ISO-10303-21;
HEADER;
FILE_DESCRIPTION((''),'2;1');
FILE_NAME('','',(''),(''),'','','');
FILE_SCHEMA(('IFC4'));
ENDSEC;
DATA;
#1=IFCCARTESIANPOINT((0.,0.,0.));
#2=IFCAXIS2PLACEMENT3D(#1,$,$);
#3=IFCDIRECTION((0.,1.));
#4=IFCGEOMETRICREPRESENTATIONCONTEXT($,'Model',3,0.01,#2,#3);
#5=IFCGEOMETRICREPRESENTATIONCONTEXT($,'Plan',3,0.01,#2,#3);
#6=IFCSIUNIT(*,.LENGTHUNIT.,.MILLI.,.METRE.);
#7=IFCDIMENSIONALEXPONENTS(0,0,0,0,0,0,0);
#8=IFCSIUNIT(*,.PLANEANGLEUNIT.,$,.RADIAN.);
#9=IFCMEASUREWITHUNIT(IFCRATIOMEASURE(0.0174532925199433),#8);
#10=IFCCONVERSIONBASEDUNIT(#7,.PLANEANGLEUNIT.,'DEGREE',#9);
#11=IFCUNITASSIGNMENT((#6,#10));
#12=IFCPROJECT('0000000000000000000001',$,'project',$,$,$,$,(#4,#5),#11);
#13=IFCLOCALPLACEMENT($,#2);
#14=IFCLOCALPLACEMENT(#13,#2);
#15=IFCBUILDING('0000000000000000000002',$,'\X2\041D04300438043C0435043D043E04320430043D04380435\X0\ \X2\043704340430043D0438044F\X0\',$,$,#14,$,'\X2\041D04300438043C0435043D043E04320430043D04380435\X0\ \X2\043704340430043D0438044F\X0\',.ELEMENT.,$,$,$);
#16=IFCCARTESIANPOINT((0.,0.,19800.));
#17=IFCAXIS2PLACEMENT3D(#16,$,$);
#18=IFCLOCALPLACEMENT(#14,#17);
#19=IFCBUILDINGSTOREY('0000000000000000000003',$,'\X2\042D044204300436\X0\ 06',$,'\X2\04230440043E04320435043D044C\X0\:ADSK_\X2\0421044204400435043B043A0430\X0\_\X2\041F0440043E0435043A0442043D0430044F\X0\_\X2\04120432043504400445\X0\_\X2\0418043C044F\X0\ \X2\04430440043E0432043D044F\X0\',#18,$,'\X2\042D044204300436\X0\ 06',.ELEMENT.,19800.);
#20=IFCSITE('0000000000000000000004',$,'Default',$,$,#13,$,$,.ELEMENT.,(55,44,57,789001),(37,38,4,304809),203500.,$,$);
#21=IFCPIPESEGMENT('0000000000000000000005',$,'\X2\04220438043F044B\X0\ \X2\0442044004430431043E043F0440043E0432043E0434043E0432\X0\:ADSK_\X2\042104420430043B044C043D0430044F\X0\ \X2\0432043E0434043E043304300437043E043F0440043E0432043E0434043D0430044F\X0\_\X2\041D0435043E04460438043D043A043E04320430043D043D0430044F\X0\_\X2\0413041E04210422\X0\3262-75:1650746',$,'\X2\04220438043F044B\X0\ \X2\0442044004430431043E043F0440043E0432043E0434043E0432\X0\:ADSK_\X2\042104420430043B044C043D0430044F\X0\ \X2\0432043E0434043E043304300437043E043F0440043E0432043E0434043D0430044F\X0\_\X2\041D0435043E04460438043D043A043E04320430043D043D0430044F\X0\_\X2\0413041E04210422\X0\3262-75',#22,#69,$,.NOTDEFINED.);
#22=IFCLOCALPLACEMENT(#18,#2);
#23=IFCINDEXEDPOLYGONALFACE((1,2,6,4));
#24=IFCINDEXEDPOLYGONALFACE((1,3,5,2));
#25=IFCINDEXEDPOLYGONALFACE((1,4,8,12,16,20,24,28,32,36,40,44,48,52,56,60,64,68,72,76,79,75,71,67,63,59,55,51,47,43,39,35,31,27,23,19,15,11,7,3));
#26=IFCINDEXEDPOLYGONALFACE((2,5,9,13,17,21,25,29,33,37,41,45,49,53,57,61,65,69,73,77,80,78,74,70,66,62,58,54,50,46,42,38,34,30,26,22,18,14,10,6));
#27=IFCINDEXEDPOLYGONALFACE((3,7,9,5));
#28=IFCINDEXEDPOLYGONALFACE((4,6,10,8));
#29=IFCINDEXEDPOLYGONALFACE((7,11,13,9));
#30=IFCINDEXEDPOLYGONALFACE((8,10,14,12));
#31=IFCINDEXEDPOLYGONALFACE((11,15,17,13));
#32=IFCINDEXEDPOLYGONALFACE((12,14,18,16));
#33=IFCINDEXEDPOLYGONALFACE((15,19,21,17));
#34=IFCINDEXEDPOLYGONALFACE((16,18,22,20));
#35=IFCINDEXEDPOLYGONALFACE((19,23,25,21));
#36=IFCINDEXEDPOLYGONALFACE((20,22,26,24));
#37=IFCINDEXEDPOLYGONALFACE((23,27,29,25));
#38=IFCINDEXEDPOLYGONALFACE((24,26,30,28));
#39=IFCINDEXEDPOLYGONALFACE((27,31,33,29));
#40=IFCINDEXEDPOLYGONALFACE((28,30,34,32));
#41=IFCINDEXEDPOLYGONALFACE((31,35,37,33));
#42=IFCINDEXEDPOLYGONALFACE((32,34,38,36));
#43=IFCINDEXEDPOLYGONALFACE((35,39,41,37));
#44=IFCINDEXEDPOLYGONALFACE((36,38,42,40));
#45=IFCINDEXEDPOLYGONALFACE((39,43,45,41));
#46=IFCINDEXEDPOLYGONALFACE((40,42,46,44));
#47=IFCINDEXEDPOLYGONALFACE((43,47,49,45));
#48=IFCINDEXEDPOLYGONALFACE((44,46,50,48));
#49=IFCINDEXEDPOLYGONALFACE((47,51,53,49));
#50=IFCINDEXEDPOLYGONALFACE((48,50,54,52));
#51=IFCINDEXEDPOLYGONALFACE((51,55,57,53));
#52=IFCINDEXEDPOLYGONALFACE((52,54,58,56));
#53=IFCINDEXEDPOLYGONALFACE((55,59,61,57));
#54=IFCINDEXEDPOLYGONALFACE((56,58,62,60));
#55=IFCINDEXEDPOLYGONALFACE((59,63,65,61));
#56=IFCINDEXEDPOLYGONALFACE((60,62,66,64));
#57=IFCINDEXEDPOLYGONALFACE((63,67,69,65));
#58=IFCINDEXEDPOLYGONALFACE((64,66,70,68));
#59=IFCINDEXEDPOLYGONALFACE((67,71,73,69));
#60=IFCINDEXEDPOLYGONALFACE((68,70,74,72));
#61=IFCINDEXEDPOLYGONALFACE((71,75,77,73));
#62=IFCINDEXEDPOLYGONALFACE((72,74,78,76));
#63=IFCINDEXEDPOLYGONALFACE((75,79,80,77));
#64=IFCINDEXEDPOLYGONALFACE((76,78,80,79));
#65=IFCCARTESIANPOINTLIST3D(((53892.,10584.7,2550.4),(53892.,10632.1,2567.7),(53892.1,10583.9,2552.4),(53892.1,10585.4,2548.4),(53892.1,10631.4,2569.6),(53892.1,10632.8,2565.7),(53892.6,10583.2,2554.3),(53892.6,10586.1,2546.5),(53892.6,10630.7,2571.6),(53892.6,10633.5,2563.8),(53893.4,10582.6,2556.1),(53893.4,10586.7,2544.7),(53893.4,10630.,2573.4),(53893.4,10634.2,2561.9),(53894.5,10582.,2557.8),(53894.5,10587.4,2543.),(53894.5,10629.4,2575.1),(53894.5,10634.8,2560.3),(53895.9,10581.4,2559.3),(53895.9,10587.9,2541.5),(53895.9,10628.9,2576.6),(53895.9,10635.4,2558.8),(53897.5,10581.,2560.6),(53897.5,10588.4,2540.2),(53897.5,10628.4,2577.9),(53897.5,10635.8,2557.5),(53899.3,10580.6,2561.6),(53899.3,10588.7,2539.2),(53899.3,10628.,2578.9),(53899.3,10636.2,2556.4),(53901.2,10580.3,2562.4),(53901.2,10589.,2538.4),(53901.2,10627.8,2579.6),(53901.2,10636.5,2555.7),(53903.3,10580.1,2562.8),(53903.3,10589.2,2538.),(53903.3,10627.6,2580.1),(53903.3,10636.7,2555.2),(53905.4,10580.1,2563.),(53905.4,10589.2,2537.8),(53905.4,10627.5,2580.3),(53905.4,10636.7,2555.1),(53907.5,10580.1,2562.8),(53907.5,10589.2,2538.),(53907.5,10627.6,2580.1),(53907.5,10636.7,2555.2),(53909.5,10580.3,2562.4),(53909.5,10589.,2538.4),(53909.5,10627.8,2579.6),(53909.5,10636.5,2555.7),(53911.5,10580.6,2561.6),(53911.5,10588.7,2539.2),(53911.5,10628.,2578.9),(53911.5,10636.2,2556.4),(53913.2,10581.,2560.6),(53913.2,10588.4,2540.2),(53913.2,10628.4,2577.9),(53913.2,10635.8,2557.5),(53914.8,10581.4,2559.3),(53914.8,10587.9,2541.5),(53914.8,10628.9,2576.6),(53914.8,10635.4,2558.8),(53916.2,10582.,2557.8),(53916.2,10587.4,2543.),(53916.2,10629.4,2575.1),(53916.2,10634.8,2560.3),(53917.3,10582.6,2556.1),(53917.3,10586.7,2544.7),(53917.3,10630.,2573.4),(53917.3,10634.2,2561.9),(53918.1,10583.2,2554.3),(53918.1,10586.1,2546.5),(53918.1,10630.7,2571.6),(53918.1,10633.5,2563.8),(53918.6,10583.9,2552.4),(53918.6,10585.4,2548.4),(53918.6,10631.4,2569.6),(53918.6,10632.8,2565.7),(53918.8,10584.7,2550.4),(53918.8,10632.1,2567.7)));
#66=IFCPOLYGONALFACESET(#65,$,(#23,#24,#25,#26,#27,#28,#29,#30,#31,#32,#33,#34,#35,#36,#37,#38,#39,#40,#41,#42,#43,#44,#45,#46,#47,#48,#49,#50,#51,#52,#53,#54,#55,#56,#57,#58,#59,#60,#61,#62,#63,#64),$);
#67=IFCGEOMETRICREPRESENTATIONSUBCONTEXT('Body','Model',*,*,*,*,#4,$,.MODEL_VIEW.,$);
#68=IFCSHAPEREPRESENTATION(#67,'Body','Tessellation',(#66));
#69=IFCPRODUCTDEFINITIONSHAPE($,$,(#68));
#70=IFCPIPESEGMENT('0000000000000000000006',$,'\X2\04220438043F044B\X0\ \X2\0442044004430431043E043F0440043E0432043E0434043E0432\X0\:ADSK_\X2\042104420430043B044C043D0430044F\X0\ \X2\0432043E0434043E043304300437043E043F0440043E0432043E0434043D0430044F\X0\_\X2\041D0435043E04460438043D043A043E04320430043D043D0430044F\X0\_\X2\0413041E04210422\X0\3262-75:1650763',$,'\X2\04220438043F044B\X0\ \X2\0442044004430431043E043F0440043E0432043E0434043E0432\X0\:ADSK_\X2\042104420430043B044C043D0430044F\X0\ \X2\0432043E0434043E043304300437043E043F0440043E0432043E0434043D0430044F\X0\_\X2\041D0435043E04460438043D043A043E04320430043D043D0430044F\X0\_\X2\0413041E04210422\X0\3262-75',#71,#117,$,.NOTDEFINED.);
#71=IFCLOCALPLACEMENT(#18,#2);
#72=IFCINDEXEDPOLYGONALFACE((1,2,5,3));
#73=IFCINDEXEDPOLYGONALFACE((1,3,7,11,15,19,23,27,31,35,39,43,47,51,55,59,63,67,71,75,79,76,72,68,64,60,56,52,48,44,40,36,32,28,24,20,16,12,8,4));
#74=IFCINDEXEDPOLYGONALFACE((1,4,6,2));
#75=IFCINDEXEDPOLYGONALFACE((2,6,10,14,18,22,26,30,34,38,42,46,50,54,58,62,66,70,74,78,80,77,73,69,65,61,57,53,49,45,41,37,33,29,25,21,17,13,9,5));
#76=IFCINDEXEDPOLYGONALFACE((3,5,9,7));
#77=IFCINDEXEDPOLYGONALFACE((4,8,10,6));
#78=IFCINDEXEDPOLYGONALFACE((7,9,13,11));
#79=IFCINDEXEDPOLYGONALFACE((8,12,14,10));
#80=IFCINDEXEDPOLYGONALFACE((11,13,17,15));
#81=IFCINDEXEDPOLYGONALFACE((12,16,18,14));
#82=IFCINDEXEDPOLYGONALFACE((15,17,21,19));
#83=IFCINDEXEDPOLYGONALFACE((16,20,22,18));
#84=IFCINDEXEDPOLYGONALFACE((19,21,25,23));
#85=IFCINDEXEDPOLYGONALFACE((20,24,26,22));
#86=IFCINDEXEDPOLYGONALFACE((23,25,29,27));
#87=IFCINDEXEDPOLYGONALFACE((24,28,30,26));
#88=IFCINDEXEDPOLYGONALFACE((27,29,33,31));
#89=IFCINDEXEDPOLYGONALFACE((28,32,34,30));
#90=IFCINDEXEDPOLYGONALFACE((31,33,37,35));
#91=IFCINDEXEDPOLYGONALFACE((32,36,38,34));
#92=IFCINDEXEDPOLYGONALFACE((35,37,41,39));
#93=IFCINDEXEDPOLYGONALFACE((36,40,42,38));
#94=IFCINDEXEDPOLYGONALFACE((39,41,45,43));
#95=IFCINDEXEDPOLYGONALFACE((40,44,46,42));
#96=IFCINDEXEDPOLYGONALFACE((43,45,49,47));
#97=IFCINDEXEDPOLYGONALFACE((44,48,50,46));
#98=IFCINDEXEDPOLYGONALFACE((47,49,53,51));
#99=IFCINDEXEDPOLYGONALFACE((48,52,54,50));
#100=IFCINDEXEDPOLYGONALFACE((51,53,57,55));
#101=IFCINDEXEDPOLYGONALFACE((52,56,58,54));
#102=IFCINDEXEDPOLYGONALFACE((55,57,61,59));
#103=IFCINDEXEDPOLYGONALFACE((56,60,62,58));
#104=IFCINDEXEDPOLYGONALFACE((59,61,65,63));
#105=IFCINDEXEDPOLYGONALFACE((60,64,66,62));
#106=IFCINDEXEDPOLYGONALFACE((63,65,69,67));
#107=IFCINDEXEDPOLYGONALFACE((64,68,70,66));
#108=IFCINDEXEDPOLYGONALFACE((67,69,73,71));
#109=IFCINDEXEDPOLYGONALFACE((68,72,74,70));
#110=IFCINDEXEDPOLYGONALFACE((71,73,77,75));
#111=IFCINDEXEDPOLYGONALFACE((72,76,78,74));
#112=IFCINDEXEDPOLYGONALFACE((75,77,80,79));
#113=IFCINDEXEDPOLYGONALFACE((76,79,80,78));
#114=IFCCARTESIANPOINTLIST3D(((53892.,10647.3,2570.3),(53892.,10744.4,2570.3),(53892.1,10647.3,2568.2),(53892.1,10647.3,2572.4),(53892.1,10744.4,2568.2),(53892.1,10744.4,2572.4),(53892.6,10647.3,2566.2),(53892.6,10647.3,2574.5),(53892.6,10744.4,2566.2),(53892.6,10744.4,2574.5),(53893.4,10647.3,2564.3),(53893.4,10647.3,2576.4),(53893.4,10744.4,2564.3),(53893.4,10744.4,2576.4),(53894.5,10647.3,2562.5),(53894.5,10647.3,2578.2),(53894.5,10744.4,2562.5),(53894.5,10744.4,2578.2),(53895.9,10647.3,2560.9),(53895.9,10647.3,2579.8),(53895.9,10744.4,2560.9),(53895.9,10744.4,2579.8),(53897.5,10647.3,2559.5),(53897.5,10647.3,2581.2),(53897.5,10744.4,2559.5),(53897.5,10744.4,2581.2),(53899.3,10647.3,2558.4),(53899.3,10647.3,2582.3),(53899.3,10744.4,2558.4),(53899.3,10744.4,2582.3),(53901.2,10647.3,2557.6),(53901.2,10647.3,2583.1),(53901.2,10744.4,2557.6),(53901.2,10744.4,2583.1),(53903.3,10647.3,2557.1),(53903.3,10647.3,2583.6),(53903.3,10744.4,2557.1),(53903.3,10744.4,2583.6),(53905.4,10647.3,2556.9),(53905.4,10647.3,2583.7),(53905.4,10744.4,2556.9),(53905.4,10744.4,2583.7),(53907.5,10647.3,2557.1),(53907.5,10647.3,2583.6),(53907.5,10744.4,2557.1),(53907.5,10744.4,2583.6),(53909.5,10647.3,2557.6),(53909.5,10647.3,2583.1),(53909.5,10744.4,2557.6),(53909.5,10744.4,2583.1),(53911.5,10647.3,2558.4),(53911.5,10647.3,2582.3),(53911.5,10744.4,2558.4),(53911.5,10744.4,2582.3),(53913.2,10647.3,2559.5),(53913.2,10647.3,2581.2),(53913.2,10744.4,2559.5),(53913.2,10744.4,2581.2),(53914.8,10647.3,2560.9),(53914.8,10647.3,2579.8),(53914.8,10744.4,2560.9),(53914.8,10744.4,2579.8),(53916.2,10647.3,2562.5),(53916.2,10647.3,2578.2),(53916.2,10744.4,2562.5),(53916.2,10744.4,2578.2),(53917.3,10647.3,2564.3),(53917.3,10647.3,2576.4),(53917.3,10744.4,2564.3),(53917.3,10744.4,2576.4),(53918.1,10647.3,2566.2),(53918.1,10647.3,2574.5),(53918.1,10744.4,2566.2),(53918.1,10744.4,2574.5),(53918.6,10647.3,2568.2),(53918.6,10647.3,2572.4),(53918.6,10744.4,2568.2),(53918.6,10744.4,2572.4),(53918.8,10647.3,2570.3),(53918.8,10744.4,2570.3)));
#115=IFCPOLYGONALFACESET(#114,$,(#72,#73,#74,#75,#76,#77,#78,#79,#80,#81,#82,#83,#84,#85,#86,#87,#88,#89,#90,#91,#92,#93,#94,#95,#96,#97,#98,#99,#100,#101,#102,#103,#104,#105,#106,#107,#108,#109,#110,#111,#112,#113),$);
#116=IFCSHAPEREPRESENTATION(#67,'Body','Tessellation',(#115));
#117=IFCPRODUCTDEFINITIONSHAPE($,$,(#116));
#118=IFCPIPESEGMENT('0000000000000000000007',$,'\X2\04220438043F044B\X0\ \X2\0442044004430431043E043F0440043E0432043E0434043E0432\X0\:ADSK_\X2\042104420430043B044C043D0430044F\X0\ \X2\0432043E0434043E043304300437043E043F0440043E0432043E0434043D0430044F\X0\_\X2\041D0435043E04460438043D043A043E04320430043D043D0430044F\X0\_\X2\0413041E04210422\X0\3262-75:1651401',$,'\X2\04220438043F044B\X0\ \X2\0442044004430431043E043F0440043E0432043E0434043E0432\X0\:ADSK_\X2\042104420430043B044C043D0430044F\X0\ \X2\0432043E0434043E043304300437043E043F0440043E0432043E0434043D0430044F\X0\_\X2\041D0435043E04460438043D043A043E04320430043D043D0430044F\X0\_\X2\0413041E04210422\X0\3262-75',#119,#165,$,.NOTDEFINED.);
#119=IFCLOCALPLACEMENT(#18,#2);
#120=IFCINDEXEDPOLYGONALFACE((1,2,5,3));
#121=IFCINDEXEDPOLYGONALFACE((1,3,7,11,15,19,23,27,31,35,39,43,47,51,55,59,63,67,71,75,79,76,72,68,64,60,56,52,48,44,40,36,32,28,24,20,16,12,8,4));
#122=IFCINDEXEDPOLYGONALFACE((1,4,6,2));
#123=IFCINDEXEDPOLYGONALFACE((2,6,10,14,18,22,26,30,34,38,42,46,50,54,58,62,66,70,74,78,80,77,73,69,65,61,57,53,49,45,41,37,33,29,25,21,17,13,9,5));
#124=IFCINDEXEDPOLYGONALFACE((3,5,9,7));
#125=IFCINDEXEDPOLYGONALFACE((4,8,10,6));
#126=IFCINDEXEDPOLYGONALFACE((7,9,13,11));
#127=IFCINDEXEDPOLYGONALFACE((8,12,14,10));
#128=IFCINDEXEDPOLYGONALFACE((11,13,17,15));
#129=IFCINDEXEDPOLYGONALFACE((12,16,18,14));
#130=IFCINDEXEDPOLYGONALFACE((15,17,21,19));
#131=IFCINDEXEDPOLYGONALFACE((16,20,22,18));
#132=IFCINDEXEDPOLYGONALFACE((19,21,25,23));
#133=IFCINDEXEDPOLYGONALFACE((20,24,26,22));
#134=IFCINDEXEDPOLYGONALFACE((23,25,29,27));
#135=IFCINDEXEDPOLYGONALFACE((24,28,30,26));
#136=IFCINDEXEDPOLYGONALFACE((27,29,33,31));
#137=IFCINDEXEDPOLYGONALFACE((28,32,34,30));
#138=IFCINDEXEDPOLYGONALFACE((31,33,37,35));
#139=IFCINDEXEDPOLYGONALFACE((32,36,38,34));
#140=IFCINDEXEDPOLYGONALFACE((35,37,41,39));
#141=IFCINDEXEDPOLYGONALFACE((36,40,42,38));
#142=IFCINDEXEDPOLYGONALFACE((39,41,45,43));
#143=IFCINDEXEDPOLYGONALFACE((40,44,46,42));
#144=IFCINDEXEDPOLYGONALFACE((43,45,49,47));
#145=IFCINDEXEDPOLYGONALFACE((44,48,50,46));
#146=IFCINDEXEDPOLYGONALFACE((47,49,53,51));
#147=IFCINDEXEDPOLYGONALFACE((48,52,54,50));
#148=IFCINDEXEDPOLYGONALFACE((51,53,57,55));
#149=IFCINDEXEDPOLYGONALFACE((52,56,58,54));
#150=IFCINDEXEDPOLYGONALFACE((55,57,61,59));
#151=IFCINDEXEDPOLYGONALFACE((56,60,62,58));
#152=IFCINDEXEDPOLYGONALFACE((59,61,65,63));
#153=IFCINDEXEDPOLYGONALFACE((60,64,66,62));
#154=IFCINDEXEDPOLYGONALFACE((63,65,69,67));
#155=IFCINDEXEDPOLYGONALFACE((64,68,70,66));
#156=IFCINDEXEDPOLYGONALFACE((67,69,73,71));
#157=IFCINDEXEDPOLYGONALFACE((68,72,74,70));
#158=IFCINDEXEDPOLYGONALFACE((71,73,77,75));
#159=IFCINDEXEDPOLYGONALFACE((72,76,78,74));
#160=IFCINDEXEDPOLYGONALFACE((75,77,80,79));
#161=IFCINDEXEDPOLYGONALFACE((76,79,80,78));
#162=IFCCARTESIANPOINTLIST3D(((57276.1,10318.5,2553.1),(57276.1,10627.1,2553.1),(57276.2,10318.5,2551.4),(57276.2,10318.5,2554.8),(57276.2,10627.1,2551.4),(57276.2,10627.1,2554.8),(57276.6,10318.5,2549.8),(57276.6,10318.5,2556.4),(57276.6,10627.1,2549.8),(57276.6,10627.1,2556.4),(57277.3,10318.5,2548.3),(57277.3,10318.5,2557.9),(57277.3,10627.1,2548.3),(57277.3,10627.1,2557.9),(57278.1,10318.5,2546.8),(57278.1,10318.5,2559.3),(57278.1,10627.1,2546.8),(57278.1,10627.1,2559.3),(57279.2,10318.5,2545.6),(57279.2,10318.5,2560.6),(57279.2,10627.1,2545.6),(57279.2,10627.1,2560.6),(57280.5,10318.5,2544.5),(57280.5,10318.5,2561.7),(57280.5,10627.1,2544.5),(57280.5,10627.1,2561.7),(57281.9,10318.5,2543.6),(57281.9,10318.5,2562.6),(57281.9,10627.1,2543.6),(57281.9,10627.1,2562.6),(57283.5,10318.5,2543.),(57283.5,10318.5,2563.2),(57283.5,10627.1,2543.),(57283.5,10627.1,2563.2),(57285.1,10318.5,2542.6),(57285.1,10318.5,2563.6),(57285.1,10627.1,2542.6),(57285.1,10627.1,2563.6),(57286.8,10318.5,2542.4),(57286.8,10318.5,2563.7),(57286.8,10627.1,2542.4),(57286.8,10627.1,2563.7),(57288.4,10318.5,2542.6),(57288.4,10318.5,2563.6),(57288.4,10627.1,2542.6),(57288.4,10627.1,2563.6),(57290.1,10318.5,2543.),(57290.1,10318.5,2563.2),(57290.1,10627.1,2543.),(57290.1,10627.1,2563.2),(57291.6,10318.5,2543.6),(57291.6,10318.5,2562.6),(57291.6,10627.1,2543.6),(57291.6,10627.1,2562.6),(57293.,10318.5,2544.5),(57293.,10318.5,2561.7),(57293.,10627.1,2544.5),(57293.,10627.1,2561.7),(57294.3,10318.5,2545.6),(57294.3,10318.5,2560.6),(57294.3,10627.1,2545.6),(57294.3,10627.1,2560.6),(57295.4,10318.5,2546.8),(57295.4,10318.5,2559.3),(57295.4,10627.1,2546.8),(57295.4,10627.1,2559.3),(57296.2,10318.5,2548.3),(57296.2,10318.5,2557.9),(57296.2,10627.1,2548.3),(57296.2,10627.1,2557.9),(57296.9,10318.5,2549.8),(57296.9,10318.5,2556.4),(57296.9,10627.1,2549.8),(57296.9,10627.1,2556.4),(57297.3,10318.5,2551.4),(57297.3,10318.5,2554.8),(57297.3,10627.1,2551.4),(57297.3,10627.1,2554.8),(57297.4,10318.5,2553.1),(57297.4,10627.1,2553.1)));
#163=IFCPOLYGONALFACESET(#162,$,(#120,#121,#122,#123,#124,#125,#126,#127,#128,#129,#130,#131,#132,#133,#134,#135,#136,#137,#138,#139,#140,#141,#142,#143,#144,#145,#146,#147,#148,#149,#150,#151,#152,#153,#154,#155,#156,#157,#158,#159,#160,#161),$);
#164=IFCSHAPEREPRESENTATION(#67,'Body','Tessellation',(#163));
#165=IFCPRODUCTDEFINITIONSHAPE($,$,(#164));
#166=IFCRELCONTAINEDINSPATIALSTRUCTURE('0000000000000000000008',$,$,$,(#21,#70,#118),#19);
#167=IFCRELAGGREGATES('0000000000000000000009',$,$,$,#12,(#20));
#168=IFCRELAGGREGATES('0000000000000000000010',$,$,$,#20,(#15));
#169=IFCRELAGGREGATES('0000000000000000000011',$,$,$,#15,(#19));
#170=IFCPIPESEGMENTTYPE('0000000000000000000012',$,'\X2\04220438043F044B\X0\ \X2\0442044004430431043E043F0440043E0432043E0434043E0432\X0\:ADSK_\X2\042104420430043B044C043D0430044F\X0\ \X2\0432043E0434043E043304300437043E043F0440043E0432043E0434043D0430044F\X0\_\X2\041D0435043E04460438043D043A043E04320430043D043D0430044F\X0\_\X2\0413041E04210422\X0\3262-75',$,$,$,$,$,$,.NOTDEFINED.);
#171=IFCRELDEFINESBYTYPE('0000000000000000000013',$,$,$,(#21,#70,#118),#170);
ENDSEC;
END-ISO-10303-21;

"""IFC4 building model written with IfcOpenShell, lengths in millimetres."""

from ifc_helpers import new_model, entity, si_unit, converted_unit, direction, frame, origin, place, context, subcontext, project, spatial, indexed_curve, outline, extrude, type_object, element, save


model = new_model("IFC4")

# Units and contexts
model_context = context("Model", 3, precision=0.01, world=origin(), true_north=direction((0.0, 1.0)))
plan_context = context("Plan", 3, precision=0.01, world=origin(), true_north=direction((0.0, 1.0)))
body_context = subcontext(model_context, "Body", "Model", "MODEL_VIEW")
ifc_project = project(units=[si_unit("LENGTHUNIT", "METRE", prefix="MILLI"), converted_unit("PLANEANGLEUNIT", "DEGREE", entity("IfcRatioMeasure", 0.0174532925199433), si_unit("PLANEANGLEUNIT", "RADIAN"), dimensions=[0, 0, 0, 0, 0, 0, 0])], contexts=[model_context, plan_context])

# Site, building, storey
site_placement = place(None, origin())
site = spatial("IfcSite", under=ifc_project, at=site_placement, Name="Default", CompositionType="ELEMENT", RefLatitude=(55, 44, 57, 789001), RefLongitude=(37, 38, 4, 304809), RefElevation=203500.0)
building_placement = place(site_placement, origin())
building = spatial("IfcBuilding", under=site, at=building_placement, Name="Наименование здания", LongName="Наименование здания", CompositionType="ELEMENT")
storey_placement = place(building_placement, frame((0.0, 0.0, 19800.0)))
storey = spatial("IfcBuildingStorey", under=building, at=storey_placement, Name="Этаж 06", ObjectType="Уровень:ADSK_Стрелка_Проектная_Вверх_Имя уровня", LongName="Этаж 06", CompositionType="ELEMENT", Elevation=19800.0)

# Pipe segments
pipe_segment_type = type_object("IfcPipeSegmentType", Name="Типы трубопроводов:ADSK_Стальная водогазопроводная_Неоцинкованная_ГОСТ3262-75", PredefinedType="NOTDEFINED")
placement = place(storey_placement, origin())
element("IfcPipeSegment", 1, at=placement, inside=storey, type_object=pipe_segment_type, Name="Типы трубопроводов:ADSK_Стальная водогазопроводная_Неоцинкованная_ГОСТ3262-75:1650746", ObjectType="Типы трубопроводов:ADSK_Стальная водогазопроводная_Неоцинкованная_ГОСТ3262-75", PredefinedType="NOTDEFINED", context=body_context, shape_type="SweptSolid", body=[
    extrude(outline(indexed_curve([(13.4, 0.0), (13.2, 2.1), (12.7, 4.1), (11.9, 6.1), (10.8, 7.9), (9.5, 9.5), (7.9, 10.8), (6.1, 11.9), (4.1, 12.7), (2.1, 13.2), (0.0, 13.4), (-2.1, 13.2), (-4.1, 12.7), (-6.1, 11.9), (-7.9, 10.8), (-9.5, 9.5), (-10.8, 7.9), (-11.9, 6.1), (-12.7, 4.1), (-13.2, 2.1), (-13.4, 0.0), (-13.2, -2.1), (-12.7, -4.1), (-11.9, -6.1), (-10.8, -7.9), (-9.5, -9.5), (-7.9, -10.8), (-6.1, -11.9), (-4.1, -12.7), (-2.1, -13.2), (0.0, -13.4), (2.1, -13.2), (4.1, -12.7), (6.1, -11.9), (7.9, -10.8), (9.5, -9.5), (10.8, -7.9), (11.9, -6.1), (12.7, -4.1), (13.2, -2.1), (13.4, 0.0)], self_intersect=False)), frame((53905.4, 10584.7, 2550.4), z_axis=(0.0, 0.939693, 0.34202), x_axis=(1.0, 0.0, 0.0)), (0.0, 0.0, 1.0), 50.5),
])
element("IfcPipeSegment", 2, at=placement, inside=storey, type_object=pipe_segment_type, Name="Типы трубопроводов:ADSK_Стальная водогазопроводная_Неоцинкованная_ГОСТ3262-75:1650763", ObjectType="Типы трубопроводов:ADSK_Стальная водогазопроводная_Неоцинкованная_ГОСТ3262-75", PredefinedType="NOTDEFINED", context=body_context, shape_type="SweptSolid", body=[
    extrude(outline(indexed_curve([(13.4, 0.0), (13.2, 2.1), (12.7, 4.1), (11.9, 6.1), (10.8, 7.9), (9.5, 9.5), (7.9, 10.8), (6.1, 11.9), (4.1, 12.7), (2.1, 13.2), (0.0, 13.4), (-2.1, 13.2), (-4.1, 12.7), (-6.1, 11.9), (-7.9, 10.8), (-9.5, 9.5), (-10.8, 7.9), (-11.9, 6.1), (-12.7, 4.1), (-13.2, 2.1), (-13.4, 0.0), (-13.2, -2.1), (-12.7, -4.1), (-11.9, -6.1), (-10.8, -7.9), (-9.5, -9.5), (-7.9, -10.8), (-6.1, -11.9), (-4.1, -12.7), (-2.1, -13.2), (0.0, -13.4), (2.1, -13.2), (4.1, -12.7), (6.1, -11.9), (7.9, -10.8), (9.5, -9.5), (10.8, -7.9), (11.9, -6.1), (12.7, -4.1), (13.2, -2.1), (13.4, 0.0)], self_intersect=False)), frame((53905.4, 10647.3, 2570.3), z_axis=(0.0, 1.0, 0.0), x_axis=(-1.0, 0.0, 0.0)), (0.0, 0.0, 1.0), 97.1),
])
element("IfcPipeSegment", 3, at=placement, inside=storey, type_object=pipe_segment_type, Name="Типы трубопроводов:ADSK_Стальная водогазопроводная_Неоцинкованная_ГОСТ3262-75:1651401", ObjectType="Типы трубопроводов:ADSK_Стальная водогазопроводная_Неоцинкованная_ГОСТ3262-75", PredefinedType="NOTDEFINED", context=body_context, shape_type="SweptSolid", body=[
    extrude(outline(indexed_curve([(10.7, 0.0), (10.5, 1.7), (10.1, 3.3), (9.5, 4.8), (8.6, 6.3), (7.5, 7.5), (6.3, 8.6), (4.8, 9.5), (3.3, 10.1), (1.7, 10.5), (0.0, 10.7), (-1.7, 10.5), (-3.3, 10.1), (-4.8, 9.5), (-6.3, 8.6), (-7.5, 7.5), (-8.6, 6.3), (-9.5, 4.8), (-10.1, 3.3), (-10.5, 1.7), (-10.7, 0.0), (-10.5, -1.7), (-10.1, -3.3), (-9.5, -4.8), (-8.6, -6.3), (-7.5, -7.5), (-6.3, -8.6), (-4.8, -9.5), (-3.3, -10.1), (-1.7, -10.5), (0.0, -10.7), (1.7, -10.5), (3.3, -10.1), (4.8, -9.5), (6.3, -8.6), (7.5, -7.5), (8.6, -6.3), (9.5, -4.8), (10.1, -3.3), (10.5, -1.7), (10.7, 0.0)], self_intersect=False)), frame((57286.8, 10318.5, 2553.1), z_axis=(0.0, 1.0, 0.0), x_axis=(-1.0, 0.0, 0.0)), (0.0, 0.0, 1.0), 308.6),
])

save(model, "model.ifc")
